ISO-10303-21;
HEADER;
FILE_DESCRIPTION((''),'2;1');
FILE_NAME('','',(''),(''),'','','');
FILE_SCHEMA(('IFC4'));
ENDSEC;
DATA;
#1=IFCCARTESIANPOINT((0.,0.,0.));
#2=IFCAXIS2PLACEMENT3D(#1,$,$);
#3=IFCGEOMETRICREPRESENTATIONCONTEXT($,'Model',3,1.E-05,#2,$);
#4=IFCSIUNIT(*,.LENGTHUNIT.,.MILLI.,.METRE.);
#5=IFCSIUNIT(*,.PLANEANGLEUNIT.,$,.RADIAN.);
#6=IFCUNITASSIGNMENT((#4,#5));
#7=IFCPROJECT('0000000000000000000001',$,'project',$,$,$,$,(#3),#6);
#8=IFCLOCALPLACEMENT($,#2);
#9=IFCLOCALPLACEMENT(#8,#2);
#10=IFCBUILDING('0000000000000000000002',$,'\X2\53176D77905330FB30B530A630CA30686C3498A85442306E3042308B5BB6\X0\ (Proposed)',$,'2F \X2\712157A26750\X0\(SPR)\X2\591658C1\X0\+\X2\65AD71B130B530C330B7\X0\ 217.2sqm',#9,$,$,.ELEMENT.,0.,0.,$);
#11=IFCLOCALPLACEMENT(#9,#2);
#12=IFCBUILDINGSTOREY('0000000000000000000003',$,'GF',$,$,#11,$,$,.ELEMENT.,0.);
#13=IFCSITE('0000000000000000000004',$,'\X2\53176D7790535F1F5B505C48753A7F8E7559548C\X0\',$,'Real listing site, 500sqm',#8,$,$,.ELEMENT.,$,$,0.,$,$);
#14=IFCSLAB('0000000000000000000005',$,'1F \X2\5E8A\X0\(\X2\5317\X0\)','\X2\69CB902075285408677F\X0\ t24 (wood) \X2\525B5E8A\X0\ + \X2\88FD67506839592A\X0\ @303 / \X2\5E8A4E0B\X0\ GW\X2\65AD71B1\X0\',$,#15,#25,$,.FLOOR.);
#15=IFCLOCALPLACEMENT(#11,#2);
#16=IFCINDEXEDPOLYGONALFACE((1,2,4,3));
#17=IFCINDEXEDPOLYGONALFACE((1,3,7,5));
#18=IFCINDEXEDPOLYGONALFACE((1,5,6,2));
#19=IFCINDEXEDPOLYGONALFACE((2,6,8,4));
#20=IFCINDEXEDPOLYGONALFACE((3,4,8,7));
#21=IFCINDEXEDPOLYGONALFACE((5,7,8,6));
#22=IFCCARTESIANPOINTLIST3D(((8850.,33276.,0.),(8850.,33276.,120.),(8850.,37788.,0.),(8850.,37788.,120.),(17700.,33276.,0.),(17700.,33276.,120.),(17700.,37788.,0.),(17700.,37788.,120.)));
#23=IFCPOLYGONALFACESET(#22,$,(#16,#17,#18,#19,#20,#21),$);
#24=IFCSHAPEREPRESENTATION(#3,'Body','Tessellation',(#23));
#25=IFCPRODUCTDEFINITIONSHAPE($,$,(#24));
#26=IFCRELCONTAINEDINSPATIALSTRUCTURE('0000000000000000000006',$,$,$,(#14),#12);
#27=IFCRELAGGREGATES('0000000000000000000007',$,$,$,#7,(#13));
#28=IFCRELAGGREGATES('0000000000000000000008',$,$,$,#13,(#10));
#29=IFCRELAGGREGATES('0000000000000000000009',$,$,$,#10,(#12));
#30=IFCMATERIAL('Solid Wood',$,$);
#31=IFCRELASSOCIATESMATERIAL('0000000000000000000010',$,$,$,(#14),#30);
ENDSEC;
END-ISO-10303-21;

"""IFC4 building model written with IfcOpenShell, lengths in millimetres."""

from ifc_helpers import new_model, si_unit, frame, frame_2d, origin, place, context, project, spatial, rectangle, extrude, material, element, save


model = new_model("IFC4")

# Units and contexts
model_context = context("Model", 3, precision=1e-05, world=origin())
ifc_project = project(units=[si_unit("LENGTHUNIT", "METRE", prefix="MILLI"), si_unit("PLANEANGLEUNIT", "RADIAN")], contexts=[model_context])

# Site, building, storey
site_placement = place(None, origin())
site = spatial("IfcSite", under=ifc_project, at=site_placement, Name="北海道弟子屈町美留和", ObjectType="Real listing site, 500sqm", CompositionType="ELEMENT", RefElevation=0.0)
building_placement = place(site_placement, origin())
building = spatial("IfcBuilding", under=site, at=building_placement, Name="北海道・サウナと水風呂のある家 (Proposed)", ObjectType="2F 無垢材(SPR)外壁+断熱サッシ 217.2sqm", CompositionType="ELEMENT", ElevationOfRefHeight=0.0, ElevationOfTerrain=0.0)
storey_placement = place(building_placement, origin())
storey = spatial("IfcBuildingStorey", under=building, at=storey_placement, Name="GF", CompositionType="ELEMENT", Elevation=0.0)

# Shared definitions
ifc_material_1 = material(Name="Solid Wood")

# Slab
slab_1_placement = place(storey_placement, frame((4425.0, 16638.0, 0.0)))
element("IfcSlab", 1, at=slab_1_placement, inside=storey, material=ifc_material_1, Name="1F 床(北)", Description="構造用合板 t24 (wood) 剛床 + 製材根太 @303 / 床下 GW断熱", PredefinedType="FLOOR", context=model_context, shape_type="SweptSolid", body=[
    extrude(rectangle(XDim=8850.0, YDim=4512.0, at=frame_2d((4425.0, 2256.0))), frame((4425.0, 16638.0, 0.0)), (0.0, 0.0, 1.0), 120.0),
])

save(model, "model.ifc")
